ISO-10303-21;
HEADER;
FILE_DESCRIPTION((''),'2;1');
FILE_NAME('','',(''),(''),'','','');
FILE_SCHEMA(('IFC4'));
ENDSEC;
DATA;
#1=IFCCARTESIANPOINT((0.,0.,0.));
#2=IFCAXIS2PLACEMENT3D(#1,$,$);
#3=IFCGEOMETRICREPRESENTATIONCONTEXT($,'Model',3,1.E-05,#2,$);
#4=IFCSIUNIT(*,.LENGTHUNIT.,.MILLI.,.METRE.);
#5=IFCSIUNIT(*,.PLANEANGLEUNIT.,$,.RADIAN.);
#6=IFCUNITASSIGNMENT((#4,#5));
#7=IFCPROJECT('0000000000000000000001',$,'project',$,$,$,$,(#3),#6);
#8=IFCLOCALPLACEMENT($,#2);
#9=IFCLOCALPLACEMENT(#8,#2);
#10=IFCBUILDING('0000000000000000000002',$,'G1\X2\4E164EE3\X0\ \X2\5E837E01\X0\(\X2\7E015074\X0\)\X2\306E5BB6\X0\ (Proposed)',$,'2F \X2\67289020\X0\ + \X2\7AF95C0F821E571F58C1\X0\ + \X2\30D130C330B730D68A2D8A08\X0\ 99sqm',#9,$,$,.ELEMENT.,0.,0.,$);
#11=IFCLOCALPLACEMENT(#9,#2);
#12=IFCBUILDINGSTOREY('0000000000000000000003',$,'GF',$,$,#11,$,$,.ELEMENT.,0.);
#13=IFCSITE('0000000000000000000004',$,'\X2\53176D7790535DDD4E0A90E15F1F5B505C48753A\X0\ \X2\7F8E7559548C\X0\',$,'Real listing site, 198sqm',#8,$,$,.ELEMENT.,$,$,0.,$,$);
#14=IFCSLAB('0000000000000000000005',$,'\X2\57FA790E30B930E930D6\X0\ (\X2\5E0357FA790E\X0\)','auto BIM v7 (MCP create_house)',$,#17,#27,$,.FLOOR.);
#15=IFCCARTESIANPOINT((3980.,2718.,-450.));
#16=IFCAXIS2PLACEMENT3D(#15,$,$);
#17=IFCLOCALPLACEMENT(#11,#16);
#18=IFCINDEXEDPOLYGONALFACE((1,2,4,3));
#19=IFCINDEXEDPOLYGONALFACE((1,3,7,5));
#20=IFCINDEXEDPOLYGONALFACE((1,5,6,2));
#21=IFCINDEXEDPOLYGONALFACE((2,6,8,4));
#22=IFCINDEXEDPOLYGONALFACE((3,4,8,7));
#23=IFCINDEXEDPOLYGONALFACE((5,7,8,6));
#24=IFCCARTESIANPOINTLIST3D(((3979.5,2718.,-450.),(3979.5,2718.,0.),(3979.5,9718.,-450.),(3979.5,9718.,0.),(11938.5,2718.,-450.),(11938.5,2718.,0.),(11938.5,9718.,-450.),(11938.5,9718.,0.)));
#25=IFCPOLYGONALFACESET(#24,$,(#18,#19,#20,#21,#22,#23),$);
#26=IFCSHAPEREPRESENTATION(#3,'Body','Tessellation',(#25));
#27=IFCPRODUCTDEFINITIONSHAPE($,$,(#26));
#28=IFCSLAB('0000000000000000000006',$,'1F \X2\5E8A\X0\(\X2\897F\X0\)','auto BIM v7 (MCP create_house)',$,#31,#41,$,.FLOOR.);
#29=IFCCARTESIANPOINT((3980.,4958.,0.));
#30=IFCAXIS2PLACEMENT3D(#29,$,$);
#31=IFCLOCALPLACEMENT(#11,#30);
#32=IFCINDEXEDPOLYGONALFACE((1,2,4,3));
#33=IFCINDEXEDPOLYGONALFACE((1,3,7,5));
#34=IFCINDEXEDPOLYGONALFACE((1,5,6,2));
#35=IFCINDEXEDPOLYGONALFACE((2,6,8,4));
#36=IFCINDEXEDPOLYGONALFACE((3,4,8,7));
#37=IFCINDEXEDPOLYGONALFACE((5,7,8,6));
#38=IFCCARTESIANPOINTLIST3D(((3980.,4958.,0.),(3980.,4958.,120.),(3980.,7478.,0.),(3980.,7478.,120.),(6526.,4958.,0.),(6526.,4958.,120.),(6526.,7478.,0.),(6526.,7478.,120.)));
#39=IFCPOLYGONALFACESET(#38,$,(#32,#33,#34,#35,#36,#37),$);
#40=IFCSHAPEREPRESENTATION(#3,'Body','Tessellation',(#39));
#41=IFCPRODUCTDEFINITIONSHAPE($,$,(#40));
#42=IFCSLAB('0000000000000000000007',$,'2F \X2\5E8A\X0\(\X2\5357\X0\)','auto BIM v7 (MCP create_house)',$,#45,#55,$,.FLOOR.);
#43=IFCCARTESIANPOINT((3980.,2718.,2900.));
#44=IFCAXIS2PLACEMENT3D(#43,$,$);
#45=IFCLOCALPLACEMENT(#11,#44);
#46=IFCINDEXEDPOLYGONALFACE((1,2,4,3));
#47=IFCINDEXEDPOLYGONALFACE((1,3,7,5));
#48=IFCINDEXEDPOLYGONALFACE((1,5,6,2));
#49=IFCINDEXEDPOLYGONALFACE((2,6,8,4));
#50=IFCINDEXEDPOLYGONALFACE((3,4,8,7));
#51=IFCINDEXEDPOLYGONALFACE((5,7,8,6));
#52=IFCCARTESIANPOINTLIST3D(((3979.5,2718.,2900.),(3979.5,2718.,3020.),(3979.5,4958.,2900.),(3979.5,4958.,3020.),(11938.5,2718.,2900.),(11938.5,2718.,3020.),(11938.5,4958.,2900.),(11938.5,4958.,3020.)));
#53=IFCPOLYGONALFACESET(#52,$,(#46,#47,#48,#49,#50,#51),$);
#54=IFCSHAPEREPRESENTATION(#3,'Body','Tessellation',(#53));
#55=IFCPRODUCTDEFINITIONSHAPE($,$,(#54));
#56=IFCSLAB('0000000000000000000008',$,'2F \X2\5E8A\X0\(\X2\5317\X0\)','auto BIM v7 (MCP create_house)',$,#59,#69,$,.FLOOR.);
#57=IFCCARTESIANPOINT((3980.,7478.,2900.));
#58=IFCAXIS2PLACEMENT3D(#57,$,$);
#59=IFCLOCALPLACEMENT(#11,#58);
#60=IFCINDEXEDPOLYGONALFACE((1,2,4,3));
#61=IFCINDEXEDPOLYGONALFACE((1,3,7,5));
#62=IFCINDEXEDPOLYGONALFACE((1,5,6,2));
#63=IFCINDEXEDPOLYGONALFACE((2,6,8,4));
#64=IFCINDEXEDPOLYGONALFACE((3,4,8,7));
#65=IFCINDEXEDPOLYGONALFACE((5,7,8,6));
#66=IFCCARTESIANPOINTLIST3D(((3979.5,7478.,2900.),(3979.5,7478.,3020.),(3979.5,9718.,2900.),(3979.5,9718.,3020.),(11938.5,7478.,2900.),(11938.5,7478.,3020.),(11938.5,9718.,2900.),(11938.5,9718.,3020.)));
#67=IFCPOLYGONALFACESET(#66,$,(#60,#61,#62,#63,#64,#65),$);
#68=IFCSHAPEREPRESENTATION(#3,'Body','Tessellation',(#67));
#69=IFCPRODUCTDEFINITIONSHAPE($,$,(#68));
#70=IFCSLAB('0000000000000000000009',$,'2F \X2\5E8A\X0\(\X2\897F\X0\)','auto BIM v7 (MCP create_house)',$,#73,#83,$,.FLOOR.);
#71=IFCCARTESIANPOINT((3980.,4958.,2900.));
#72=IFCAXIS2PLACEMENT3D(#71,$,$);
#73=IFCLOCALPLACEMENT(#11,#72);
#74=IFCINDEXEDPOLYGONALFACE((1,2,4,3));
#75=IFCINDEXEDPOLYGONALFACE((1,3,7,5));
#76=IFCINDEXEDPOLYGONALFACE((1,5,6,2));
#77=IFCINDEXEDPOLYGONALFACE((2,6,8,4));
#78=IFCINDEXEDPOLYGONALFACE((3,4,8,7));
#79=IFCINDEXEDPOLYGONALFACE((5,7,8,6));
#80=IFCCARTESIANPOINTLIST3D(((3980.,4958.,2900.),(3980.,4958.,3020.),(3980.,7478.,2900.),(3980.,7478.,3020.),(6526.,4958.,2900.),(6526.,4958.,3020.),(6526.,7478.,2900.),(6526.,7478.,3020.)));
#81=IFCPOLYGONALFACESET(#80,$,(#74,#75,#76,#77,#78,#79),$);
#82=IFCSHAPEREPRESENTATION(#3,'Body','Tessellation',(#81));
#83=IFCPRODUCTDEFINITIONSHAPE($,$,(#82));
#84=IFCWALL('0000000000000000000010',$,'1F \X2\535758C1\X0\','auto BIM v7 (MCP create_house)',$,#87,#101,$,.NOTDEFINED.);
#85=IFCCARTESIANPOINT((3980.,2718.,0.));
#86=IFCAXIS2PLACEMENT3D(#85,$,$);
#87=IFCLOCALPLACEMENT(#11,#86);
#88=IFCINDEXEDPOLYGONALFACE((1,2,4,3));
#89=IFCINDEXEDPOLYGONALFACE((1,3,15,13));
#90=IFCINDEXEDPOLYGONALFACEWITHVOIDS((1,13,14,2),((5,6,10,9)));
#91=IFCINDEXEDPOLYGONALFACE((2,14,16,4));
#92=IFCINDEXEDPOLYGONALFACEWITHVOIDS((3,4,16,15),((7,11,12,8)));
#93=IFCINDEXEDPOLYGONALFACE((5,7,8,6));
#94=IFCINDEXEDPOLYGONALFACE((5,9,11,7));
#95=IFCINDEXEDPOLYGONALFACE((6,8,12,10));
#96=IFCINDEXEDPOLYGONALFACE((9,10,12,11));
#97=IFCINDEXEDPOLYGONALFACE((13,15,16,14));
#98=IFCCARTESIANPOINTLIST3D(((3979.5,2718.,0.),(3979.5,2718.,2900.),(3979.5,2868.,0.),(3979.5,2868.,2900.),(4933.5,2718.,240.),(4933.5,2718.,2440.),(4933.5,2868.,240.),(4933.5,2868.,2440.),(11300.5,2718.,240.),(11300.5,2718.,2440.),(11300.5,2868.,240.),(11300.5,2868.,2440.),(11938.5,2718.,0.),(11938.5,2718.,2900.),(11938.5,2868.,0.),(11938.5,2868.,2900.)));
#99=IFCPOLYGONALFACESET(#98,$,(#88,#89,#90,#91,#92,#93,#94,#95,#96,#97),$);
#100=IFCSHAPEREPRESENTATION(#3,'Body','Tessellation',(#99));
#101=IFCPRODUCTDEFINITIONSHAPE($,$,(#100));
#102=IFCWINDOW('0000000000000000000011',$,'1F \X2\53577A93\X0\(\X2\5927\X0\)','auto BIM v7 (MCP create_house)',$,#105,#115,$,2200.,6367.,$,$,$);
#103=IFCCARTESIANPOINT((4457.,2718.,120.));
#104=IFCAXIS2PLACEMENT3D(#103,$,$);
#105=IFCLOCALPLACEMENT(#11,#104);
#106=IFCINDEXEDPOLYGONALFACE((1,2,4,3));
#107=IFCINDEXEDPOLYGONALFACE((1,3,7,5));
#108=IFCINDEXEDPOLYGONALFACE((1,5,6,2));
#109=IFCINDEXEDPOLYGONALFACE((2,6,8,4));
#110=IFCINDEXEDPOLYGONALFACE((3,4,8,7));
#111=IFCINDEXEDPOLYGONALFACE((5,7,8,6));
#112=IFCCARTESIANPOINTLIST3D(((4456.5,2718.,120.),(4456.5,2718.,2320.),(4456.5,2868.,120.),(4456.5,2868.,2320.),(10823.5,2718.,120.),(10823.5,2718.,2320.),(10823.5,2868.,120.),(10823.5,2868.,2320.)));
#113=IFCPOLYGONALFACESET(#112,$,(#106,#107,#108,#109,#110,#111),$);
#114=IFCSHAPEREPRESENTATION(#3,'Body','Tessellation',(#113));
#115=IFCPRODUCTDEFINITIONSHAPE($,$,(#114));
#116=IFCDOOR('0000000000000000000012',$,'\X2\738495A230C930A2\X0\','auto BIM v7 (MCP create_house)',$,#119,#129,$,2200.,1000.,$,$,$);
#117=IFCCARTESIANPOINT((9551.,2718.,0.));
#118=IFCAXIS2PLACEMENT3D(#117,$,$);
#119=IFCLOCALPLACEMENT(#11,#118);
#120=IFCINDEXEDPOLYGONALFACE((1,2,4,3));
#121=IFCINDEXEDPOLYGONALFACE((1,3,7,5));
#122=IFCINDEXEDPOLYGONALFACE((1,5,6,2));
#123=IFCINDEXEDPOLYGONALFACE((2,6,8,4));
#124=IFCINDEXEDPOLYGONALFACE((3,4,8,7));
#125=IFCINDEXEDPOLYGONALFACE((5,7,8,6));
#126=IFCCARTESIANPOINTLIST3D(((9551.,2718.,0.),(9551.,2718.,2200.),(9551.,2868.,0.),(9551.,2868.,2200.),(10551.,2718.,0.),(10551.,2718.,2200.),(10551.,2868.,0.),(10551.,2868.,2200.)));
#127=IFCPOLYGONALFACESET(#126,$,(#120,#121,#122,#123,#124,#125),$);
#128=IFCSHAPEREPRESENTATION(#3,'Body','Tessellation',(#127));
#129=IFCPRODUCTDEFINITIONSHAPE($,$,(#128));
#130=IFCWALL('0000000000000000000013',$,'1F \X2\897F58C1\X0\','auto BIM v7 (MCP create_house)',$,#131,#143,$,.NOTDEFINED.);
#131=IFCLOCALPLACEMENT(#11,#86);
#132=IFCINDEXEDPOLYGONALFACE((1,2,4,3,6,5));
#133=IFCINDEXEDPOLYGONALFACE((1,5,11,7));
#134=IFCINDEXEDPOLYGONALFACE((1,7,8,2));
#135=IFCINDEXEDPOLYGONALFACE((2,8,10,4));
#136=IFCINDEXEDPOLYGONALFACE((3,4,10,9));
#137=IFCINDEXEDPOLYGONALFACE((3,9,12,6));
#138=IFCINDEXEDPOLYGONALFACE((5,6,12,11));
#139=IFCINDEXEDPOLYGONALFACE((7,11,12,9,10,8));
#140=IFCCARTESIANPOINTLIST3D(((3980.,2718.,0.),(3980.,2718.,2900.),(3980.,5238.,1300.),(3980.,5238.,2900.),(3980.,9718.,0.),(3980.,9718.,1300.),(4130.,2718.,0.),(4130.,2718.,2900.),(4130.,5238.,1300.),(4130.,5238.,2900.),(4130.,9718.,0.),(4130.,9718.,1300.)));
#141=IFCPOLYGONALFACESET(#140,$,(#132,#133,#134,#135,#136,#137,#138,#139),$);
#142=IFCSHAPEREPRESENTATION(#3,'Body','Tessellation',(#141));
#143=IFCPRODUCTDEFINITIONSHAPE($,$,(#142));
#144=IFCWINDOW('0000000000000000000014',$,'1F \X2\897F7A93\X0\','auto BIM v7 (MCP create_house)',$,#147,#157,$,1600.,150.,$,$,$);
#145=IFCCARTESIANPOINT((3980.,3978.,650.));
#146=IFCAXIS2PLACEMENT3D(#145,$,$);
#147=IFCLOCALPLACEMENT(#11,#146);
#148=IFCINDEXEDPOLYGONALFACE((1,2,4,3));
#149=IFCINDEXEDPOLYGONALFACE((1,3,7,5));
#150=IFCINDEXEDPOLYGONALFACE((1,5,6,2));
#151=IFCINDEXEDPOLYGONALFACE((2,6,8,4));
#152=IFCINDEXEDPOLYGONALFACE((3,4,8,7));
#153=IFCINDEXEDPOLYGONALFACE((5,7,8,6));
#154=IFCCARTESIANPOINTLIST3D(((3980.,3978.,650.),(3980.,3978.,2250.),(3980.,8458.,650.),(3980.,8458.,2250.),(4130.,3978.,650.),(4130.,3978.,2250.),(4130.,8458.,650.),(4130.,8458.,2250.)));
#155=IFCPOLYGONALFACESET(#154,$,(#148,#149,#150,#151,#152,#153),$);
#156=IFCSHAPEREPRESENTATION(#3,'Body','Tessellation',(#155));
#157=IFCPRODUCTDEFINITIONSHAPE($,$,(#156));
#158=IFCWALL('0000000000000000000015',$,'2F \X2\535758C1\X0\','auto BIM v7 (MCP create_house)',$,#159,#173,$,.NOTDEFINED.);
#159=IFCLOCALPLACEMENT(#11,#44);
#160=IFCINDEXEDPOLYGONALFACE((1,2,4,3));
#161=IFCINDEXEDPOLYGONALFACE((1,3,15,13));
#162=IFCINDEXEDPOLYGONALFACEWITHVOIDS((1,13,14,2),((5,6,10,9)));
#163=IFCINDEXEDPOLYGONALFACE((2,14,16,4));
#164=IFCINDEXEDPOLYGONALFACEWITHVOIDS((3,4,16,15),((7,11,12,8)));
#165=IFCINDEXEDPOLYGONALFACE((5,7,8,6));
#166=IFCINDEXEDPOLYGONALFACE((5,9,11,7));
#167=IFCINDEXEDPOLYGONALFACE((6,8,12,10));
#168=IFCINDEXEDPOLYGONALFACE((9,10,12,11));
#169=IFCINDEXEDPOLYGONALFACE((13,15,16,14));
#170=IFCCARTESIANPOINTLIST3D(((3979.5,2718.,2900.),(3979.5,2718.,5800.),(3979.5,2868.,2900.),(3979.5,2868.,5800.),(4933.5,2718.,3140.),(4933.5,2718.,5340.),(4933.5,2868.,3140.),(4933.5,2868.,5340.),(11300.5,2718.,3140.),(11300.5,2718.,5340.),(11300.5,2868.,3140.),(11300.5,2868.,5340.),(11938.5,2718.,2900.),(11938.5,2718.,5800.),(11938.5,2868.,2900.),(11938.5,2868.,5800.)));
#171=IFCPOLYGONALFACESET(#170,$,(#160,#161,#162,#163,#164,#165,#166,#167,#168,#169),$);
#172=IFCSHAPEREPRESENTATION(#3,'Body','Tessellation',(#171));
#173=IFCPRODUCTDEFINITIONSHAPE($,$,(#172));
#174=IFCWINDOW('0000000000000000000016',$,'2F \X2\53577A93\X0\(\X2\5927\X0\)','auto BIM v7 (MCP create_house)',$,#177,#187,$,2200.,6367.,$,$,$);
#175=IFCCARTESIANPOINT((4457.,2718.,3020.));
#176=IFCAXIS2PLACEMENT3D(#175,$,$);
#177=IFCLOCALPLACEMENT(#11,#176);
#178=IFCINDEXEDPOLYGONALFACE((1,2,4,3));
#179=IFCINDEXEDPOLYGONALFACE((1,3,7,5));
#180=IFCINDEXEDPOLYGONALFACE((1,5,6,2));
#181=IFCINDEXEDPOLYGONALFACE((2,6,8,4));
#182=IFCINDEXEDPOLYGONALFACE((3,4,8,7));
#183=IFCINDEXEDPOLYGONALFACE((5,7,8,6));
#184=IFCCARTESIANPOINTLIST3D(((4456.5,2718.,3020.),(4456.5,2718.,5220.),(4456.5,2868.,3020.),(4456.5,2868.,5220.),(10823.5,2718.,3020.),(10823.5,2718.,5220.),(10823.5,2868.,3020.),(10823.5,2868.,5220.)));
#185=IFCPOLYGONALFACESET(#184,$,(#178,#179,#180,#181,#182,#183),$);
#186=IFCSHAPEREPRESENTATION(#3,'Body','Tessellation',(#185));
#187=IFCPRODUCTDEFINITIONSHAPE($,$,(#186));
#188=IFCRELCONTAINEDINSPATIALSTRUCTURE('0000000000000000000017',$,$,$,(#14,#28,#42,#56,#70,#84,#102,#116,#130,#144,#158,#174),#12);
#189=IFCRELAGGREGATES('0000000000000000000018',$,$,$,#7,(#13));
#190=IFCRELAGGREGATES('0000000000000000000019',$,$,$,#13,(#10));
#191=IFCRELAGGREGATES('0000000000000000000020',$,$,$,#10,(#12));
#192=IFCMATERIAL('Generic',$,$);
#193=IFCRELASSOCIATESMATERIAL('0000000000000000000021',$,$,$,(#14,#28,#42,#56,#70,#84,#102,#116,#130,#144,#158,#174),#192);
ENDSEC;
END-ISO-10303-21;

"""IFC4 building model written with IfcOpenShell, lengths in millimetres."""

from ifc_helpers import new_model, si_unit, frame, frame_2d, origin, place, context, project, spatial, rectangle, extrude, material, element, fill, save


model = new_model("IFC4")

# Units and contexts
model_context = context("Model", 3, precision=1e-05, world=origin())
ifc_project = project(units=[si_unit("LENGTHUNIT", "METRE", prefix="MILLI"), si_unit("PLANEANGLEUNIT", "RADIAN")], contexts=[model_context])

# Site, building, storey
site_placement = place(None, origin())
site = spatial("IfcSite", under=ifc_project, at=site_placement, Name="北海道川上郡弟子屈町 美留和", ObjectType="Real listing site, 198sqm", CompositionType="ELEMENT", RefElevation=0.0)
building_placement = place(site_placement, origin())
building = spatial("IfcBuilding", under=site, at=building_placement, Name="G1世代 広縁(縁側)の家 (Proposed)", ObjectType="2F 木造 + 竹小舞土壁 + パッシブ設計 99sqm", CompositionType="ELEMENT", ElevationOfRefHeight=0.0, ElevationOfTerrain=0.0)
storey_placement = place(building_placement, origin())
storey = spatial("IfcBuildingStorey", under=building, at=storey_placement, Name="GF", CompositionType="ELEMENT", Elevation=0.0)

# Slabs
ifc_material = material(Name="Generic")
slab_1_placement = place(storey_placement, frame((3980.0, 2718.0, -450.0)))
element("IfcSlab", 1, at=slab_1_placement, inside=storey, material=ifc_material, Name="基礎スラブ (布基礎)", Description="auto BIM v7 (MCP create_house)", PredefinedType="FLOOR", context=model_context, shape_type="SweptSolid", body=[
    extrude(rectangle(XDim=7959.0, YDim=7000.0, at=frame_2d((3979.0, 3500.0))), frame((3980.0, 2718.0, -450.0)), (0.0, 0.0, 1.0), 450.0),
])
slab_2_placement = place(storey_placement, frame((3980.0, 4958.0, 0.0)))
element("IfcSlab", 2, at=slab_2_placement, inside=storey, material=ifc_material, Name="1F 床(西)", Description="auto BIM v7 (MCP create_house)", PredefinedType="FLOOR", context=model_context, shape_type="SweptSolid", body=[
    extrude(rectangle(XDim=2546.0, YDim=2520.0, at=frame_2d((1273.0, 1260.0))), frame((3980.0, 4958.0, 0.0)), (0.0, 0.0, 1.0), 120.0),
])
slab_3_placement = place(storey_placement, frame((3980.0, 2718.0, 2900.0)))
element("IfcSlab", 3, at=slab_3_placement, inside=storey, material=ifc_material, Name="2F 床(南)", Description="auto BIM v7 (MCP create_house)", PredefinedType="FLOOR", context=model_context, shape_type="SweptSolid", body=[
    extrude(rectangle(XDim=7959.0, YDim=2240.0, at=frame_2d((3979.0, 1120.0))), frame((3980.0, 2718.0, 2900.0)), (0.0, 0.0, 1.0), 120.0),
])
slab_4_placement = place(storey_placement, frame((3980.0, 7478.0, 2900.0)))
element("IfcSlab", 4, at=slab_4_placement, inside=storey, material=ifc_material, Name="2F 床(北)", Description="auto BIM v7 (MCP create_house)", PredefinedType="FLOOR", context=model_context, shape_type="SweptSolid", body=[
    extrude(rectangle(XDim=7959.0, YDim=2240.0, at=frame_2d((3979.0, 1120.0))), frame((3980.0, 7478.0, 2900.0)), (0.0, 0.0, 1.0), 120.0),
])
slab_5_placement = place(storey_placement, frame((3980.0, 4958.0, 2900.0)))
element("IfcSlab", 5, at=slab_5_placement, inside=storey, material=ifc_material, Name="2F 床(西)", Description="auto BIM v7 (MCP create_house)", PredefinedType="FLOOR", context=model_context, shape_type="SweptSolid", body=[
    extrude(rectangle(XDim=2546.0, YDim=2520.0, at=frame_2d((1273.0, 1260.0))), frame((3980.0, 4958.0, 2900.0)), (0.0, 0.0, 1.0), 120.0),
])

# Wall, openings, window, door
wall_1_placement = place(storey_placement, frame((3980.0, 2718.0, 0.0)))
wall_1 = element("IfcWall", 6, at=wall_1_placement, inside=storey, material=ifc_material, Name="1F 南壁", Description="auto BIM v7 (MCP create_house)", PredefinedType="NOTDEFINED", context=model_context, shape_type="SweptSolid", body=[
    extrude(rectangle(XDim=7959.0, YDim=150.0, at=frame_2d((3979.0, 75.0))), frame((3980.0, 2718.0, 0.0)), (0.0, 0.0, 1.0), 2900.0),
])
opening_1_placement = place(storey_placement, frame((4457.0, 2718.0, 120.0)))
opening_1 = element("IfcOpeningElement", 7, at=opening_1_placement, cuts=wall_1, PredefinedType="NOTDEFINED", context=model_context, shape_type="SweptSolid", body=[
    extrude(rectangle(XDim=6367.0, YDim=150.0, at=frame_2d((3183.0, 75.0))), frame((4457.0, 2718.0, 120.0)), (0.0, 0.0, 1.0), 2200.0),
])
opening_2_placement = place(storey_placement, frame((9551.0, 2718.0, 0.0)))
opening_2 = element("IfcOpeningElement", 8, at=opening_2_placement, cuts=wall_1, PredefinedType="NOTDEFINED", context=model_context, shape_type="SweptSolid", body=[
    extrude(rectangle(XDim=1000.0, YDim=150.0, at=frame_2d((500.0, 75.0))), frame((9551.0, 2718.0, 0.0)), (0.0, 0.0, 1.0), 2200.0),
])
window_1_placement = place(storey_placement, frame((4457.0, 2718.0, 120.0)))
window_1 = element("IfcWindow", 9, at=window_1_placement, inside=storey, material=ifc_material, Name="1F 南窓(大)", Description="auto BIM v7 (MCP create_house)", OverallHeight=2200.0, OverallWidth=6367.0, context=model_context, shape_type="SweptSolid", body=[
    extrude(rectangle(XDim=6367.0, YDim=150.0, at=frame_2d((3183.0, 75.0))), frame((4457.0, 2718.0, 120.0)), (0.0, 0.0, 1.0), 2200.0),
])
fill(opening_1, window_1)
door_placement = place(storey_placement, frame((9551.0, 2718.0, 0.0)))
door = element("IfcDoor", 10, at=door_placement, inside=storey, material=ifc_material, Name="玄関ドア", Description="auto BIM v7 (MCP create_house)", OverallHeight=2200.0, OverallWidth=1000.0, context=model_context, shape_type="SweptSolid", body=[
    extrude(rectangle(XDim=1000.0, YDim=150.0, at=frame_2d((500.0, 75.0))), frame((9551.0, 2718.0, 0.0)), (0.0, 0.0, 1.0), 2200.0),
])
fill(opening_2, door)

# Walls, openings, windows
wall_2_placement = place(storey_placement, frame((3980.0, 2718.0, 0.0)))
wall_2 = element("IfcWall", 11, at=wall_2_placement, inside=storey, material=ifc_material, Name="1F 西壁", Description="auto BIM v7 (MCP create_house)", PredefinedType="NOTDEFINED", context=model_context, shape_type="SweptSolid", body=[
    extrude(rectangle(XDim=150.0, YDim=7000.0, at=frame_2d((75.0, 3500.0))), frame((3980.0, 2718.0, 0.0)), (0.0, 0.0, 1.0), 2900.0),
])
opening_3_placement = place(storey_placement, frame((3980.0, 3978.0, 650.0)))
opening_3 = element("IfcOpeningElement", 12, at=opening_3_placement, cuts=wall_2, PredefinedType="NOTDEFINED", context=model_context, shape_type="SweptSolid", body=[
    extrude(rectangle(XDim=150.0, YDim=4480.0, at=frame_2d((75.0, 2240.0))), frame((3980.0, 3978.0, 650.0)), (0.0, 0.0, 1.0), 1600.0),
])
window_2_placement = place(storey_placement, frame((3980.0, 3978.0, 650.0)))
window_2 = element("IfcWindow", 13, at=window_2_placement, inside=storey, material=ifc_material, Name="1F 西窓", Description="auto BIM v7 (MCP create_house)", OverallHeight=1600.0, OverallWidth=150.0, context=model_context, shape_type="SweptSolid", body=[
    extrude(rectangle(XDim=150.0, YDim=4480.0, at=frame_2d((75.0, 2240.0))), frame((3980.0, 3978.0, 650.0)), (0.0, 0.0, 1.0), 1600.0),
])
fill(opening_3, window_2)
wall_3_placement = place(storey_placement, frame((3980.0, 2718.0, 2900.0)))
wall_3 = element("IfcWall", 14, at=wall_3_placement, inside=storey, material=ifc_material, Name="2F 南壁", Description="auto BIM v7 (MCP create_house)", PredefinedType="NOTDEFINED", context=model_context, shape_type="SweptSolid", body=[
    extrude(rectangle(XDim=7959.0, YDim=150.0, at=frame_2d((3979.0, 75.0))), frame((3980.0, 2718.0, 2900.0)), (0.0, 0.0, 1.0), 2900.0),
])
opening_4_placement = place(storey_placement, frame((4457.0, 2718.0, 3020.0)))
opening_4 = element("IfcOpeningElement", 15, at=opening_4_placement, cuts=wall_3, PredefinedType="NOTDEFINED", context=model_context, shape_type="SweptSolid", body=[
    extrude(rectangle(XDim=6367.0, YDim=150.0, at=frame_2d((3183.0, 75.0))), frame((4457.0, 2718.0, 3020.0)), (0.0, 0.0, 1.0), 2200.0),
])
window_3_placement = place(storey_placement, frame((4457.0, 2718.0, 3020.0)))
window_3 = element("IfcWindow", 16, at=window_3_placement, inside=storey, material=ifc_material, Name="2F 南窓(大)", Description="auto BIM v7 (MCP create_house)", OverallHeight=2200.0, OverallWidth=6367.0, context=model_context, shape_type="SweptSolid", body=[
    extrude(rectangle(XDim=6367.0, YDim=150.0, at=frame_2d((3183.0, 75.0))), frame((4457.0, 2718.0, 3020.0)), (0.0, 0.0, 1.0), 2200.0),
])
fill(opening_4, window_3)

save(model, "model.ifc")
